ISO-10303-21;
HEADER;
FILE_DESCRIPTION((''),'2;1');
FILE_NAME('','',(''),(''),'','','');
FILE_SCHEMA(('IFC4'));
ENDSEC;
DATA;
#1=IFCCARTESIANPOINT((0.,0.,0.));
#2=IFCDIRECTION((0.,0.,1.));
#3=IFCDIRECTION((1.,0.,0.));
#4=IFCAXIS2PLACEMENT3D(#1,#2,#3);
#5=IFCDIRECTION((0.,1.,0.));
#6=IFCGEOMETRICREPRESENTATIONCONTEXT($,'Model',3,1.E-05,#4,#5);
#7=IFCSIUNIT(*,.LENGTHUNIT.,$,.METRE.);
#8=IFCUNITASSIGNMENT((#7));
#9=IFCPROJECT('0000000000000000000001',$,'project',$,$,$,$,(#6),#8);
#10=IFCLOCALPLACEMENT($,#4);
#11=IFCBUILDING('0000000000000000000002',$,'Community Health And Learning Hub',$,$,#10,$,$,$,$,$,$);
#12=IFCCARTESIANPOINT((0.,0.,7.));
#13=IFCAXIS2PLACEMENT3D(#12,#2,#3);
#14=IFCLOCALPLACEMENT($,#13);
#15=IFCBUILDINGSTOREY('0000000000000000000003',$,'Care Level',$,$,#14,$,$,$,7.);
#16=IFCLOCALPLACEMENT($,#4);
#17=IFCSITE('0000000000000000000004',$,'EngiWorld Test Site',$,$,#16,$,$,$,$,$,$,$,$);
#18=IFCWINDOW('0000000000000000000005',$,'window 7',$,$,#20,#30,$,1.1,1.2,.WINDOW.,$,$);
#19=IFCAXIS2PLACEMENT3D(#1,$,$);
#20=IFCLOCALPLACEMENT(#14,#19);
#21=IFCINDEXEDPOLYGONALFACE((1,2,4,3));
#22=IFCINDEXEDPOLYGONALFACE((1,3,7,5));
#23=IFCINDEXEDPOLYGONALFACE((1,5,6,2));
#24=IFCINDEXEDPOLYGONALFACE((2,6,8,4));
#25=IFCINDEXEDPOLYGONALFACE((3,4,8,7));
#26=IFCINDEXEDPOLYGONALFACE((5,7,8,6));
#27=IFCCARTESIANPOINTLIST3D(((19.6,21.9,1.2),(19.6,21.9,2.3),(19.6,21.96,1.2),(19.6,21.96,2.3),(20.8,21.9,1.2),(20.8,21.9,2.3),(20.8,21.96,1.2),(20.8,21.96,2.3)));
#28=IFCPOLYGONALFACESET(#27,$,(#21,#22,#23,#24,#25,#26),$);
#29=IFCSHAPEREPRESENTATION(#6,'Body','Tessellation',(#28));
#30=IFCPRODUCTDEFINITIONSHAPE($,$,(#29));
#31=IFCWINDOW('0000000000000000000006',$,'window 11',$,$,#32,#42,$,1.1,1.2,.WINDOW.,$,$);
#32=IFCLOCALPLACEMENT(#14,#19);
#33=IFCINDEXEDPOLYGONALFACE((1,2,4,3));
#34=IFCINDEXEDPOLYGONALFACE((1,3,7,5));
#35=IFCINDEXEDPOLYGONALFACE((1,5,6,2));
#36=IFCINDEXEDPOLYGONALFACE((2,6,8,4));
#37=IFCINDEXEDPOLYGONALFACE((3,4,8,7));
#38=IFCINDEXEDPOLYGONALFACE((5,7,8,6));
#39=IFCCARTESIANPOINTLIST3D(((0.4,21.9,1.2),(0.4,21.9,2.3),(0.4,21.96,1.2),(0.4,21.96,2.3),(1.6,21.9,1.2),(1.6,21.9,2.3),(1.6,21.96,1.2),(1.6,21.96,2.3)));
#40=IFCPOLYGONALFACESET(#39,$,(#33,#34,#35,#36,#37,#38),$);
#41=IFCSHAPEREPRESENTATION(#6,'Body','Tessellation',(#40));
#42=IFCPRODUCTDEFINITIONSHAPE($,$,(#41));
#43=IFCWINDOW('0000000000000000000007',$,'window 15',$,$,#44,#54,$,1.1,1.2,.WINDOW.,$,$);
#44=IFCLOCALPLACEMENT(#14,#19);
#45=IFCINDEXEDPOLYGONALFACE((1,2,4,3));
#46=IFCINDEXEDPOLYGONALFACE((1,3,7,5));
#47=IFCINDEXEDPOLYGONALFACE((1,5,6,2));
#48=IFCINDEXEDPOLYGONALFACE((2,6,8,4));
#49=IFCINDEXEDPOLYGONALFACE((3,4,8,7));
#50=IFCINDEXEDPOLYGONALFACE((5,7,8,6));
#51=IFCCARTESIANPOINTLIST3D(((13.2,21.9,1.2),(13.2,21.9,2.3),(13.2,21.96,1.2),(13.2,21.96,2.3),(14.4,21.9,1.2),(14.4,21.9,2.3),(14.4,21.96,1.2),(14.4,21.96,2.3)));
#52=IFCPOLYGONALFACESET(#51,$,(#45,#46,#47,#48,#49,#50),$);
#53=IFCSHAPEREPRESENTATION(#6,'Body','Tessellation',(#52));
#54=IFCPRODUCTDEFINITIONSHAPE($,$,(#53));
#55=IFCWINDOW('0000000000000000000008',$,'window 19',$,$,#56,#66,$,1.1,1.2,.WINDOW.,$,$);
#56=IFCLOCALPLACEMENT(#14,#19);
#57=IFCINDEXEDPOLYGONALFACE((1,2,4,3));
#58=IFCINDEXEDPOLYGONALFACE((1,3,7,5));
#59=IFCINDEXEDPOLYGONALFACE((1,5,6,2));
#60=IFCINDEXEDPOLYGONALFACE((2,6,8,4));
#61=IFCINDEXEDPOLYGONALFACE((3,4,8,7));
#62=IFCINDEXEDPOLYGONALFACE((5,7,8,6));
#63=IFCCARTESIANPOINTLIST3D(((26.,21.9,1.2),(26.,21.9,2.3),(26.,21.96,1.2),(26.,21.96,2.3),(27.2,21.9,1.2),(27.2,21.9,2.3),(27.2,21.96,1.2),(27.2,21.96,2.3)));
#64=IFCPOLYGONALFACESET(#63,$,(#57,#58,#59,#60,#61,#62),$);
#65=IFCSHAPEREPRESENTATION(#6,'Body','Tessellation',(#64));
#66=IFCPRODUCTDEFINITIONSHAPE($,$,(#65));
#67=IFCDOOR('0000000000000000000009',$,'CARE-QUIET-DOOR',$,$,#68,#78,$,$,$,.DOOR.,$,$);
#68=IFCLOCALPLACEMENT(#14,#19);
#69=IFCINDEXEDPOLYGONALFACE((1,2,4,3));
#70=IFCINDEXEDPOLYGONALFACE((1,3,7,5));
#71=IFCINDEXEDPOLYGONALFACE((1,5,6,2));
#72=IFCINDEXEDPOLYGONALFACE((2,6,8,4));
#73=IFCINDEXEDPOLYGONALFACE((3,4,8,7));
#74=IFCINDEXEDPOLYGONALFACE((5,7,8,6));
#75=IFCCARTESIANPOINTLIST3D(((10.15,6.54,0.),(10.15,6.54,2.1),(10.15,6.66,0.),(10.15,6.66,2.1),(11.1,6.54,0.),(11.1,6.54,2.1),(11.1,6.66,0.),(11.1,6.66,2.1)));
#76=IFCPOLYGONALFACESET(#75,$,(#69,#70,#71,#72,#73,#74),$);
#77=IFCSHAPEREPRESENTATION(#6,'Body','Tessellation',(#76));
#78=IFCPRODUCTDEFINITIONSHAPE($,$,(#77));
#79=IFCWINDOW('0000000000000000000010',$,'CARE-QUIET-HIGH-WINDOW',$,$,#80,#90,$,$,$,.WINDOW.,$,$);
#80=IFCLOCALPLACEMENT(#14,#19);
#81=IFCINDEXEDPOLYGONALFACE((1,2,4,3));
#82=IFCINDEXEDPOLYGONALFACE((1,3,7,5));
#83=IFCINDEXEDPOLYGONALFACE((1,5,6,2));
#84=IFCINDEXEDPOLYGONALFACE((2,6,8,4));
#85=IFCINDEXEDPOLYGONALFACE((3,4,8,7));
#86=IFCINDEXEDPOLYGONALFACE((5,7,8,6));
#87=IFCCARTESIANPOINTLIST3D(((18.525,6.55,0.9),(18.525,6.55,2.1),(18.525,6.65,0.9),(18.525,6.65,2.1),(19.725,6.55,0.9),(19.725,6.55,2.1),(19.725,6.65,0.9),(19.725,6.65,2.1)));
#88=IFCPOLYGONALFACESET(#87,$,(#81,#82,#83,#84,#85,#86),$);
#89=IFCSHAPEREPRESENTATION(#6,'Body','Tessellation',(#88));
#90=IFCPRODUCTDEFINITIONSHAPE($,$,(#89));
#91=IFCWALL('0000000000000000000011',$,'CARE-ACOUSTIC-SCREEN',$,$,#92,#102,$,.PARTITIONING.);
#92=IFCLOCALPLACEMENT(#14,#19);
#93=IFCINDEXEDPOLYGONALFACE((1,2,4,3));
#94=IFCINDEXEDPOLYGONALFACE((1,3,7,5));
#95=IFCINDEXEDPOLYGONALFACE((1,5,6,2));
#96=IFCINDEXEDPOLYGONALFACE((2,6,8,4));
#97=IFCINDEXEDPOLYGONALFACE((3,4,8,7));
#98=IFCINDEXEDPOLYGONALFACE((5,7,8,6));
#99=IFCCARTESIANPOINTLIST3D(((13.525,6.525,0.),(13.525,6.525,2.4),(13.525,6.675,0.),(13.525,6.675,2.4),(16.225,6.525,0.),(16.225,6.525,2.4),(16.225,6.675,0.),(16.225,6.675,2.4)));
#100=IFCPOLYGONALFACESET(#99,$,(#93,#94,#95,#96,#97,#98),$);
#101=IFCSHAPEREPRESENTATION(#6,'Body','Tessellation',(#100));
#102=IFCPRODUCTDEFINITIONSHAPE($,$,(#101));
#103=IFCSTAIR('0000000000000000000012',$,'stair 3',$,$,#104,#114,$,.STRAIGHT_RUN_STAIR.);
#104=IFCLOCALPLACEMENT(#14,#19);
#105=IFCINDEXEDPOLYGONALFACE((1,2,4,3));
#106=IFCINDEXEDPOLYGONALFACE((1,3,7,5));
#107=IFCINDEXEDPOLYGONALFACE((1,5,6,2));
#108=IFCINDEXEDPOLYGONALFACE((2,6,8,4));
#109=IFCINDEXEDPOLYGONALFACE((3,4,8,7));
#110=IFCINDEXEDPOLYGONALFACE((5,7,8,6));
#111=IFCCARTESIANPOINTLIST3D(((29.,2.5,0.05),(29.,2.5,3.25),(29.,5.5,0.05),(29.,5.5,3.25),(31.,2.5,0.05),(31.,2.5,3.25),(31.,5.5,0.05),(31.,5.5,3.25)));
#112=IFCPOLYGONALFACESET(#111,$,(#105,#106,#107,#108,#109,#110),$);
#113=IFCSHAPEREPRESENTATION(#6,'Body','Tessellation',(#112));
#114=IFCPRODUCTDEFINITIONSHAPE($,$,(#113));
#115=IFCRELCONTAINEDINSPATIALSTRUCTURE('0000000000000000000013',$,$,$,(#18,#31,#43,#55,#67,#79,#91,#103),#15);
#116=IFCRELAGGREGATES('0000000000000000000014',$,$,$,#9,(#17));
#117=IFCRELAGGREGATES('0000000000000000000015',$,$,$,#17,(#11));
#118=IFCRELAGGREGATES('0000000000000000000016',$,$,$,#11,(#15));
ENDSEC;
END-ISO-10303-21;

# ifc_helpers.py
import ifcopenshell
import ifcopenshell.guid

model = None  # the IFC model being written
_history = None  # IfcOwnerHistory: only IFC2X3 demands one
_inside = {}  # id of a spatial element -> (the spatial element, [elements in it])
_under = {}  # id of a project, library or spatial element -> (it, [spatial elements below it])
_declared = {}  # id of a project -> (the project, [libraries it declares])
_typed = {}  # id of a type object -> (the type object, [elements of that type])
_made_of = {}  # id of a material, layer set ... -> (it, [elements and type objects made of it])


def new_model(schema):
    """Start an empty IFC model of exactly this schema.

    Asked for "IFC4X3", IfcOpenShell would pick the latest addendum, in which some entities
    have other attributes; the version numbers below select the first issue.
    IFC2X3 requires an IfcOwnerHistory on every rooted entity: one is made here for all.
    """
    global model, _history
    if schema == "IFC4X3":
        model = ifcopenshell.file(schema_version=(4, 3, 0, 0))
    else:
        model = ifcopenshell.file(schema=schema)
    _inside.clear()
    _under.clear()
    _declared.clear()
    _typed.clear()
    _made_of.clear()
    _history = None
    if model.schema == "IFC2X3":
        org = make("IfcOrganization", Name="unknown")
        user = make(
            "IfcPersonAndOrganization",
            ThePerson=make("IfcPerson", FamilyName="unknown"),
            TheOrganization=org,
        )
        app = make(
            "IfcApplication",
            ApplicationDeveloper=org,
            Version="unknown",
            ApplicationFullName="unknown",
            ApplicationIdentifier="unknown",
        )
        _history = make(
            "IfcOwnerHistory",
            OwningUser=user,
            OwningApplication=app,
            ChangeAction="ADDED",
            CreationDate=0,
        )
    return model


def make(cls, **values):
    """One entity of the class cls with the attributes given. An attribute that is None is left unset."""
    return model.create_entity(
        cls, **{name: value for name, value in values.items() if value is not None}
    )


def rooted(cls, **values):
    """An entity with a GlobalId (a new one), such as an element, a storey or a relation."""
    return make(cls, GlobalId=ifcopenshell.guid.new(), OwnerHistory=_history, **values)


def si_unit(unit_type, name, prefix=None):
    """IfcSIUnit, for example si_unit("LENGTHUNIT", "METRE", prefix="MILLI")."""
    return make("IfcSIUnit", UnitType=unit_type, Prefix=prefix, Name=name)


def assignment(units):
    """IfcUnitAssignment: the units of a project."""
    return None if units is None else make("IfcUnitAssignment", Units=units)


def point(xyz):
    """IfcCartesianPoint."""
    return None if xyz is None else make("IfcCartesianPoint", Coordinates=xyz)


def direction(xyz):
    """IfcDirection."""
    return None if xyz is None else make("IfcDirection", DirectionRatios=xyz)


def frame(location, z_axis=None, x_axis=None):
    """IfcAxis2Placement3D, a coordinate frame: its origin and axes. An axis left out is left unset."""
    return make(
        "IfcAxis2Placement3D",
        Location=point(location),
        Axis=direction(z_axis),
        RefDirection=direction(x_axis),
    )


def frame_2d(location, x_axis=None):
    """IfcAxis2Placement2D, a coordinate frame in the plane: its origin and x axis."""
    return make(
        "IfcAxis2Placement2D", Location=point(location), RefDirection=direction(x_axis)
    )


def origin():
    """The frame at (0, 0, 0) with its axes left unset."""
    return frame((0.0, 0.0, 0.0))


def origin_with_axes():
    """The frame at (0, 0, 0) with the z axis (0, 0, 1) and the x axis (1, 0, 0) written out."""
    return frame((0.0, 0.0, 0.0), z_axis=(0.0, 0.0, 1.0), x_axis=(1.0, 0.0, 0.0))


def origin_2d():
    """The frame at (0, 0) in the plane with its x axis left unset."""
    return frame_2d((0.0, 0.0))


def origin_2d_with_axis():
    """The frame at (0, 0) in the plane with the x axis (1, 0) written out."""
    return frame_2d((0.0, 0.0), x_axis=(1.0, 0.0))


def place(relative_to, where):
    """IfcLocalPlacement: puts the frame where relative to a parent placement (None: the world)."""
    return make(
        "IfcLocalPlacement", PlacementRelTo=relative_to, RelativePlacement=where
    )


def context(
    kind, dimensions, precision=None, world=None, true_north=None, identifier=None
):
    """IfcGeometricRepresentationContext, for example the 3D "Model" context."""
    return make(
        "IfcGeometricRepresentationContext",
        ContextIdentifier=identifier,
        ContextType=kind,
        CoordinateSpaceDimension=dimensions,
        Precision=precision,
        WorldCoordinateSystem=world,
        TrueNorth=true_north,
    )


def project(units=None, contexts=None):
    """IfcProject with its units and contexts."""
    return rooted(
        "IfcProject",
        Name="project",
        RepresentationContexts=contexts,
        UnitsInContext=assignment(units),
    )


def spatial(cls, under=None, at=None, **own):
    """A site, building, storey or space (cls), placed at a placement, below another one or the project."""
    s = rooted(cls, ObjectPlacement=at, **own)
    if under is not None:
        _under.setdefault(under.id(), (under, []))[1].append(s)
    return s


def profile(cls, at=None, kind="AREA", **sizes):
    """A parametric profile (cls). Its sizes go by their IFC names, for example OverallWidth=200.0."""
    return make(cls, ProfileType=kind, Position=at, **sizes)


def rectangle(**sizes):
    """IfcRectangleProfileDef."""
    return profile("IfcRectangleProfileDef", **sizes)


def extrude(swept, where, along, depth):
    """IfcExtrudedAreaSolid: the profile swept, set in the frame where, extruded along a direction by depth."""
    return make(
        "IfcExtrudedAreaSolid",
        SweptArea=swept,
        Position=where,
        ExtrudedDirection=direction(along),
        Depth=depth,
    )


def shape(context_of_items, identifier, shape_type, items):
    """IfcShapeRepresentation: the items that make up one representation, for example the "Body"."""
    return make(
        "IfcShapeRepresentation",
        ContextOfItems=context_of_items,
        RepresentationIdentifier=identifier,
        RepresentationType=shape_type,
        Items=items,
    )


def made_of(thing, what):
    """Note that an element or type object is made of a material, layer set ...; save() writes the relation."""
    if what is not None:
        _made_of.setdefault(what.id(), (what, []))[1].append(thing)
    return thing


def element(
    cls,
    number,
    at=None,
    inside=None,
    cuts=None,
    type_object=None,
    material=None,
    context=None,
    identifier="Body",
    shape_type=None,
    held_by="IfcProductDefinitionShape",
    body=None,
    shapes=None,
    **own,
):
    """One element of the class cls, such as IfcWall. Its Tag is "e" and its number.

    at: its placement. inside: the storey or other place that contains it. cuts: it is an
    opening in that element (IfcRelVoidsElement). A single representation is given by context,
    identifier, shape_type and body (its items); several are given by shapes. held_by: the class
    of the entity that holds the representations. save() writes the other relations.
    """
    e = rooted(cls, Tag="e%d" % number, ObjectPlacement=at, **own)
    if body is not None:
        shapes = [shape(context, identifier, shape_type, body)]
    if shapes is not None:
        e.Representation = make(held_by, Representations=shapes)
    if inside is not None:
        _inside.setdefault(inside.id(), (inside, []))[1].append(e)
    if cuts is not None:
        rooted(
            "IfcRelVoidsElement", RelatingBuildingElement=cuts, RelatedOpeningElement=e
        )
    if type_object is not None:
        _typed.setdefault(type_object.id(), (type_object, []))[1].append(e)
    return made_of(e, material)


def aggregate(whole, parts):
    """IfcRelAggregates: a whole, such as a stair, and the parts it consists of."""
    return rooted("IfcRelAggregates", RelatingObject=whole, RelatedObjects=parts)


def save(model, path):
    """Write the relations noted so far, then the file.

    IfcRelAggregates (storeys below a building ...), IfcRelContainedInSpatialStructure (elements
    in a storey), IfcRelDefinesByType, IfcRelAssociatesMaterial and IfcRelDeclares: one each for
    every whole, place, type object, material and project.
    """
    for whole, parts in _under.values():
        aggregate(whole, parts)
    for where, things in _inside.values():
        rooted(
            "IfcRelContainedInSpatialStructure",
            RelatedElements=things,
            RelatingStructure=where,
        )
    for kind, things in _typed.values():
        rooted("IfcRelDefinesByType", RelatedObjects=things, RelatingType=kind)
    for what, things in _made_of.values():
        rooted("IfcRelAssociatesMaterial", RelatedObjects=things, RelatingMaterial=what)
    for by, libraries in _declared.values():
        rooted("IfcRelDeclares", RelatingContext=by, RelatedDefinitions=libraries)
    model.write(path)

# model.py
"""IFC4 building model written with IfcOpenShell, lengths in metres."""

from ifc_helpers import new_model, si_unit, direction, frame, origin, origin_with_axes, origin_2d, origin_2d_with_axis, place, context, project, spatial, rectangle, extrude, element, save


model = new_model("IFC4")

# Units and contexts
model_context = context("Model", 3, precision=1e-05, world=origin_with_axes(), true_north=direction((0.0, 1.0, 0.0)))
ifc_project = project(units=[si_unit("LENGTHUNIT", "METRE")], contexts=[model_context])

# Site, building, storey
site_placement = place(None, origin_with_axes())
site = spatial("IfcSite", under=ifc_project, at=site_placement, Name="EngiWorld Test Site")
building_placement = place(None, origin_with_axes())
building = spatial("IfcBuilding", under=site, at=building_placement, Name="Community Health And Learning Hub")
storey_placement = place(None, frame((0.0, 0.0, 7.0), z_axis=(0.0, 0.0, 1.0), x_axis=(1.0, 0.0, 0.0)))
storey = spatial("IfcBuildingStorey", under=building, at=storey_placement, Name="Care Level", Elevation=7.0)

# Windows
for number, where, z_axis, x_axis, name in (
    (1, (20.2, 21.93, 8.2), (0.0, 0.0, 1.0), (1.0, 0.0, 0.0), "window 7"),
    (2, (1.0, 21.93, 8.2), (0.0, 0.0, 1.0), (1.0, 0.0, 0.0), "window 11"),
    (3, (13.8, 21.93, 8.2), (0.0, 0.0, 1.0), (1.0, 0.0, 0.0), "window 15"),
    (4, (26.6, 21.93, 8.2), (0.0, 0.0, 1.0), (1.0, 0.0, 0.0), "window 19"),
):
    element("IfcWindow", number, at=place(None, frame(where, z_axis=z_axis, x_axis=x_axis)), inside=storey, Name=name, OverallHeight=1.1, OverallWidth=1.2, PredefinedType="WINDOW", context=model_context, shape_type="SweptSolid", body=[
        extrude(rectangle(XDim=1.2, YDim=0.06, at=origin_2d_with_axis()), origin_with_axes(), (0.0, 0.0, 1.0), 1.1),
    ])

# Door
door_placement = place(None, frame((10.625, 6.6, 7.0)))
element("IfcDoor", 5, at=door_placement, inside=storey, Name="CARE-QUIET-DOOR", PredefinedType="DOOR", context=model_context, shape_type="SweptSolid", body=[
    extrude(rectangle(XDim=0.95, YDim=0.12, at=origin_2d()), origin(), (0.0, 0.0, 1.0), 2.1),
])

# Window
window_placement = place(None, frame((19.125, 6.6, 7.9)))
element("IfcWindow", 6, at=window_placement, inside=storey, Name="CARE-QUIET-HIGH-WINDOW", PredefinedType="WINDOW", context=model_context, shape_type="SweptSolid", body=[
    extrude(rectangle(XDim=1.2, YDim=0.1, at=origin_2d()), origin(), (0.0, 0.0, 1.0), 1.2),
])

# Wall
wall_1_placement = place(None, frame((14.875, 6.6, 7.0)))
element("IfcWall", 7, at=wall_1_placement, inside=storey, Name="CARE-ACOUSTIC-SCREEN", PredefinedType="PARTITIONING", context=model_context, shape_type="SweptSolid", body=[
    extrude(rectangle(XDim=2.7, YDim=0.15, at=origin_2d()), origin(), (0.0, 0.0, 1.0), 2.4),
])

# Stair
stair_placement = place(None, frame((30.0, 4.0, 7.05), z_axis=(0.0, 0.0, 1.0), x_axis=(1.0, 0.0, 0.0)))
element("IfcStair", 8, at=stair_placement, inside=storey, Name="stair 3", PredefinedType="STRAIGHT_RUN_STAIR", context=model_context, shape_type="SweptSolid", body=[
    extrude(rectangle(XDim=2.0, YDim=3.0, at=origin_2d_with_axis()), origin_with_axes(), (0.0, 0.0, 1.0), 3.2),
])

save(model, "model.ifc")
